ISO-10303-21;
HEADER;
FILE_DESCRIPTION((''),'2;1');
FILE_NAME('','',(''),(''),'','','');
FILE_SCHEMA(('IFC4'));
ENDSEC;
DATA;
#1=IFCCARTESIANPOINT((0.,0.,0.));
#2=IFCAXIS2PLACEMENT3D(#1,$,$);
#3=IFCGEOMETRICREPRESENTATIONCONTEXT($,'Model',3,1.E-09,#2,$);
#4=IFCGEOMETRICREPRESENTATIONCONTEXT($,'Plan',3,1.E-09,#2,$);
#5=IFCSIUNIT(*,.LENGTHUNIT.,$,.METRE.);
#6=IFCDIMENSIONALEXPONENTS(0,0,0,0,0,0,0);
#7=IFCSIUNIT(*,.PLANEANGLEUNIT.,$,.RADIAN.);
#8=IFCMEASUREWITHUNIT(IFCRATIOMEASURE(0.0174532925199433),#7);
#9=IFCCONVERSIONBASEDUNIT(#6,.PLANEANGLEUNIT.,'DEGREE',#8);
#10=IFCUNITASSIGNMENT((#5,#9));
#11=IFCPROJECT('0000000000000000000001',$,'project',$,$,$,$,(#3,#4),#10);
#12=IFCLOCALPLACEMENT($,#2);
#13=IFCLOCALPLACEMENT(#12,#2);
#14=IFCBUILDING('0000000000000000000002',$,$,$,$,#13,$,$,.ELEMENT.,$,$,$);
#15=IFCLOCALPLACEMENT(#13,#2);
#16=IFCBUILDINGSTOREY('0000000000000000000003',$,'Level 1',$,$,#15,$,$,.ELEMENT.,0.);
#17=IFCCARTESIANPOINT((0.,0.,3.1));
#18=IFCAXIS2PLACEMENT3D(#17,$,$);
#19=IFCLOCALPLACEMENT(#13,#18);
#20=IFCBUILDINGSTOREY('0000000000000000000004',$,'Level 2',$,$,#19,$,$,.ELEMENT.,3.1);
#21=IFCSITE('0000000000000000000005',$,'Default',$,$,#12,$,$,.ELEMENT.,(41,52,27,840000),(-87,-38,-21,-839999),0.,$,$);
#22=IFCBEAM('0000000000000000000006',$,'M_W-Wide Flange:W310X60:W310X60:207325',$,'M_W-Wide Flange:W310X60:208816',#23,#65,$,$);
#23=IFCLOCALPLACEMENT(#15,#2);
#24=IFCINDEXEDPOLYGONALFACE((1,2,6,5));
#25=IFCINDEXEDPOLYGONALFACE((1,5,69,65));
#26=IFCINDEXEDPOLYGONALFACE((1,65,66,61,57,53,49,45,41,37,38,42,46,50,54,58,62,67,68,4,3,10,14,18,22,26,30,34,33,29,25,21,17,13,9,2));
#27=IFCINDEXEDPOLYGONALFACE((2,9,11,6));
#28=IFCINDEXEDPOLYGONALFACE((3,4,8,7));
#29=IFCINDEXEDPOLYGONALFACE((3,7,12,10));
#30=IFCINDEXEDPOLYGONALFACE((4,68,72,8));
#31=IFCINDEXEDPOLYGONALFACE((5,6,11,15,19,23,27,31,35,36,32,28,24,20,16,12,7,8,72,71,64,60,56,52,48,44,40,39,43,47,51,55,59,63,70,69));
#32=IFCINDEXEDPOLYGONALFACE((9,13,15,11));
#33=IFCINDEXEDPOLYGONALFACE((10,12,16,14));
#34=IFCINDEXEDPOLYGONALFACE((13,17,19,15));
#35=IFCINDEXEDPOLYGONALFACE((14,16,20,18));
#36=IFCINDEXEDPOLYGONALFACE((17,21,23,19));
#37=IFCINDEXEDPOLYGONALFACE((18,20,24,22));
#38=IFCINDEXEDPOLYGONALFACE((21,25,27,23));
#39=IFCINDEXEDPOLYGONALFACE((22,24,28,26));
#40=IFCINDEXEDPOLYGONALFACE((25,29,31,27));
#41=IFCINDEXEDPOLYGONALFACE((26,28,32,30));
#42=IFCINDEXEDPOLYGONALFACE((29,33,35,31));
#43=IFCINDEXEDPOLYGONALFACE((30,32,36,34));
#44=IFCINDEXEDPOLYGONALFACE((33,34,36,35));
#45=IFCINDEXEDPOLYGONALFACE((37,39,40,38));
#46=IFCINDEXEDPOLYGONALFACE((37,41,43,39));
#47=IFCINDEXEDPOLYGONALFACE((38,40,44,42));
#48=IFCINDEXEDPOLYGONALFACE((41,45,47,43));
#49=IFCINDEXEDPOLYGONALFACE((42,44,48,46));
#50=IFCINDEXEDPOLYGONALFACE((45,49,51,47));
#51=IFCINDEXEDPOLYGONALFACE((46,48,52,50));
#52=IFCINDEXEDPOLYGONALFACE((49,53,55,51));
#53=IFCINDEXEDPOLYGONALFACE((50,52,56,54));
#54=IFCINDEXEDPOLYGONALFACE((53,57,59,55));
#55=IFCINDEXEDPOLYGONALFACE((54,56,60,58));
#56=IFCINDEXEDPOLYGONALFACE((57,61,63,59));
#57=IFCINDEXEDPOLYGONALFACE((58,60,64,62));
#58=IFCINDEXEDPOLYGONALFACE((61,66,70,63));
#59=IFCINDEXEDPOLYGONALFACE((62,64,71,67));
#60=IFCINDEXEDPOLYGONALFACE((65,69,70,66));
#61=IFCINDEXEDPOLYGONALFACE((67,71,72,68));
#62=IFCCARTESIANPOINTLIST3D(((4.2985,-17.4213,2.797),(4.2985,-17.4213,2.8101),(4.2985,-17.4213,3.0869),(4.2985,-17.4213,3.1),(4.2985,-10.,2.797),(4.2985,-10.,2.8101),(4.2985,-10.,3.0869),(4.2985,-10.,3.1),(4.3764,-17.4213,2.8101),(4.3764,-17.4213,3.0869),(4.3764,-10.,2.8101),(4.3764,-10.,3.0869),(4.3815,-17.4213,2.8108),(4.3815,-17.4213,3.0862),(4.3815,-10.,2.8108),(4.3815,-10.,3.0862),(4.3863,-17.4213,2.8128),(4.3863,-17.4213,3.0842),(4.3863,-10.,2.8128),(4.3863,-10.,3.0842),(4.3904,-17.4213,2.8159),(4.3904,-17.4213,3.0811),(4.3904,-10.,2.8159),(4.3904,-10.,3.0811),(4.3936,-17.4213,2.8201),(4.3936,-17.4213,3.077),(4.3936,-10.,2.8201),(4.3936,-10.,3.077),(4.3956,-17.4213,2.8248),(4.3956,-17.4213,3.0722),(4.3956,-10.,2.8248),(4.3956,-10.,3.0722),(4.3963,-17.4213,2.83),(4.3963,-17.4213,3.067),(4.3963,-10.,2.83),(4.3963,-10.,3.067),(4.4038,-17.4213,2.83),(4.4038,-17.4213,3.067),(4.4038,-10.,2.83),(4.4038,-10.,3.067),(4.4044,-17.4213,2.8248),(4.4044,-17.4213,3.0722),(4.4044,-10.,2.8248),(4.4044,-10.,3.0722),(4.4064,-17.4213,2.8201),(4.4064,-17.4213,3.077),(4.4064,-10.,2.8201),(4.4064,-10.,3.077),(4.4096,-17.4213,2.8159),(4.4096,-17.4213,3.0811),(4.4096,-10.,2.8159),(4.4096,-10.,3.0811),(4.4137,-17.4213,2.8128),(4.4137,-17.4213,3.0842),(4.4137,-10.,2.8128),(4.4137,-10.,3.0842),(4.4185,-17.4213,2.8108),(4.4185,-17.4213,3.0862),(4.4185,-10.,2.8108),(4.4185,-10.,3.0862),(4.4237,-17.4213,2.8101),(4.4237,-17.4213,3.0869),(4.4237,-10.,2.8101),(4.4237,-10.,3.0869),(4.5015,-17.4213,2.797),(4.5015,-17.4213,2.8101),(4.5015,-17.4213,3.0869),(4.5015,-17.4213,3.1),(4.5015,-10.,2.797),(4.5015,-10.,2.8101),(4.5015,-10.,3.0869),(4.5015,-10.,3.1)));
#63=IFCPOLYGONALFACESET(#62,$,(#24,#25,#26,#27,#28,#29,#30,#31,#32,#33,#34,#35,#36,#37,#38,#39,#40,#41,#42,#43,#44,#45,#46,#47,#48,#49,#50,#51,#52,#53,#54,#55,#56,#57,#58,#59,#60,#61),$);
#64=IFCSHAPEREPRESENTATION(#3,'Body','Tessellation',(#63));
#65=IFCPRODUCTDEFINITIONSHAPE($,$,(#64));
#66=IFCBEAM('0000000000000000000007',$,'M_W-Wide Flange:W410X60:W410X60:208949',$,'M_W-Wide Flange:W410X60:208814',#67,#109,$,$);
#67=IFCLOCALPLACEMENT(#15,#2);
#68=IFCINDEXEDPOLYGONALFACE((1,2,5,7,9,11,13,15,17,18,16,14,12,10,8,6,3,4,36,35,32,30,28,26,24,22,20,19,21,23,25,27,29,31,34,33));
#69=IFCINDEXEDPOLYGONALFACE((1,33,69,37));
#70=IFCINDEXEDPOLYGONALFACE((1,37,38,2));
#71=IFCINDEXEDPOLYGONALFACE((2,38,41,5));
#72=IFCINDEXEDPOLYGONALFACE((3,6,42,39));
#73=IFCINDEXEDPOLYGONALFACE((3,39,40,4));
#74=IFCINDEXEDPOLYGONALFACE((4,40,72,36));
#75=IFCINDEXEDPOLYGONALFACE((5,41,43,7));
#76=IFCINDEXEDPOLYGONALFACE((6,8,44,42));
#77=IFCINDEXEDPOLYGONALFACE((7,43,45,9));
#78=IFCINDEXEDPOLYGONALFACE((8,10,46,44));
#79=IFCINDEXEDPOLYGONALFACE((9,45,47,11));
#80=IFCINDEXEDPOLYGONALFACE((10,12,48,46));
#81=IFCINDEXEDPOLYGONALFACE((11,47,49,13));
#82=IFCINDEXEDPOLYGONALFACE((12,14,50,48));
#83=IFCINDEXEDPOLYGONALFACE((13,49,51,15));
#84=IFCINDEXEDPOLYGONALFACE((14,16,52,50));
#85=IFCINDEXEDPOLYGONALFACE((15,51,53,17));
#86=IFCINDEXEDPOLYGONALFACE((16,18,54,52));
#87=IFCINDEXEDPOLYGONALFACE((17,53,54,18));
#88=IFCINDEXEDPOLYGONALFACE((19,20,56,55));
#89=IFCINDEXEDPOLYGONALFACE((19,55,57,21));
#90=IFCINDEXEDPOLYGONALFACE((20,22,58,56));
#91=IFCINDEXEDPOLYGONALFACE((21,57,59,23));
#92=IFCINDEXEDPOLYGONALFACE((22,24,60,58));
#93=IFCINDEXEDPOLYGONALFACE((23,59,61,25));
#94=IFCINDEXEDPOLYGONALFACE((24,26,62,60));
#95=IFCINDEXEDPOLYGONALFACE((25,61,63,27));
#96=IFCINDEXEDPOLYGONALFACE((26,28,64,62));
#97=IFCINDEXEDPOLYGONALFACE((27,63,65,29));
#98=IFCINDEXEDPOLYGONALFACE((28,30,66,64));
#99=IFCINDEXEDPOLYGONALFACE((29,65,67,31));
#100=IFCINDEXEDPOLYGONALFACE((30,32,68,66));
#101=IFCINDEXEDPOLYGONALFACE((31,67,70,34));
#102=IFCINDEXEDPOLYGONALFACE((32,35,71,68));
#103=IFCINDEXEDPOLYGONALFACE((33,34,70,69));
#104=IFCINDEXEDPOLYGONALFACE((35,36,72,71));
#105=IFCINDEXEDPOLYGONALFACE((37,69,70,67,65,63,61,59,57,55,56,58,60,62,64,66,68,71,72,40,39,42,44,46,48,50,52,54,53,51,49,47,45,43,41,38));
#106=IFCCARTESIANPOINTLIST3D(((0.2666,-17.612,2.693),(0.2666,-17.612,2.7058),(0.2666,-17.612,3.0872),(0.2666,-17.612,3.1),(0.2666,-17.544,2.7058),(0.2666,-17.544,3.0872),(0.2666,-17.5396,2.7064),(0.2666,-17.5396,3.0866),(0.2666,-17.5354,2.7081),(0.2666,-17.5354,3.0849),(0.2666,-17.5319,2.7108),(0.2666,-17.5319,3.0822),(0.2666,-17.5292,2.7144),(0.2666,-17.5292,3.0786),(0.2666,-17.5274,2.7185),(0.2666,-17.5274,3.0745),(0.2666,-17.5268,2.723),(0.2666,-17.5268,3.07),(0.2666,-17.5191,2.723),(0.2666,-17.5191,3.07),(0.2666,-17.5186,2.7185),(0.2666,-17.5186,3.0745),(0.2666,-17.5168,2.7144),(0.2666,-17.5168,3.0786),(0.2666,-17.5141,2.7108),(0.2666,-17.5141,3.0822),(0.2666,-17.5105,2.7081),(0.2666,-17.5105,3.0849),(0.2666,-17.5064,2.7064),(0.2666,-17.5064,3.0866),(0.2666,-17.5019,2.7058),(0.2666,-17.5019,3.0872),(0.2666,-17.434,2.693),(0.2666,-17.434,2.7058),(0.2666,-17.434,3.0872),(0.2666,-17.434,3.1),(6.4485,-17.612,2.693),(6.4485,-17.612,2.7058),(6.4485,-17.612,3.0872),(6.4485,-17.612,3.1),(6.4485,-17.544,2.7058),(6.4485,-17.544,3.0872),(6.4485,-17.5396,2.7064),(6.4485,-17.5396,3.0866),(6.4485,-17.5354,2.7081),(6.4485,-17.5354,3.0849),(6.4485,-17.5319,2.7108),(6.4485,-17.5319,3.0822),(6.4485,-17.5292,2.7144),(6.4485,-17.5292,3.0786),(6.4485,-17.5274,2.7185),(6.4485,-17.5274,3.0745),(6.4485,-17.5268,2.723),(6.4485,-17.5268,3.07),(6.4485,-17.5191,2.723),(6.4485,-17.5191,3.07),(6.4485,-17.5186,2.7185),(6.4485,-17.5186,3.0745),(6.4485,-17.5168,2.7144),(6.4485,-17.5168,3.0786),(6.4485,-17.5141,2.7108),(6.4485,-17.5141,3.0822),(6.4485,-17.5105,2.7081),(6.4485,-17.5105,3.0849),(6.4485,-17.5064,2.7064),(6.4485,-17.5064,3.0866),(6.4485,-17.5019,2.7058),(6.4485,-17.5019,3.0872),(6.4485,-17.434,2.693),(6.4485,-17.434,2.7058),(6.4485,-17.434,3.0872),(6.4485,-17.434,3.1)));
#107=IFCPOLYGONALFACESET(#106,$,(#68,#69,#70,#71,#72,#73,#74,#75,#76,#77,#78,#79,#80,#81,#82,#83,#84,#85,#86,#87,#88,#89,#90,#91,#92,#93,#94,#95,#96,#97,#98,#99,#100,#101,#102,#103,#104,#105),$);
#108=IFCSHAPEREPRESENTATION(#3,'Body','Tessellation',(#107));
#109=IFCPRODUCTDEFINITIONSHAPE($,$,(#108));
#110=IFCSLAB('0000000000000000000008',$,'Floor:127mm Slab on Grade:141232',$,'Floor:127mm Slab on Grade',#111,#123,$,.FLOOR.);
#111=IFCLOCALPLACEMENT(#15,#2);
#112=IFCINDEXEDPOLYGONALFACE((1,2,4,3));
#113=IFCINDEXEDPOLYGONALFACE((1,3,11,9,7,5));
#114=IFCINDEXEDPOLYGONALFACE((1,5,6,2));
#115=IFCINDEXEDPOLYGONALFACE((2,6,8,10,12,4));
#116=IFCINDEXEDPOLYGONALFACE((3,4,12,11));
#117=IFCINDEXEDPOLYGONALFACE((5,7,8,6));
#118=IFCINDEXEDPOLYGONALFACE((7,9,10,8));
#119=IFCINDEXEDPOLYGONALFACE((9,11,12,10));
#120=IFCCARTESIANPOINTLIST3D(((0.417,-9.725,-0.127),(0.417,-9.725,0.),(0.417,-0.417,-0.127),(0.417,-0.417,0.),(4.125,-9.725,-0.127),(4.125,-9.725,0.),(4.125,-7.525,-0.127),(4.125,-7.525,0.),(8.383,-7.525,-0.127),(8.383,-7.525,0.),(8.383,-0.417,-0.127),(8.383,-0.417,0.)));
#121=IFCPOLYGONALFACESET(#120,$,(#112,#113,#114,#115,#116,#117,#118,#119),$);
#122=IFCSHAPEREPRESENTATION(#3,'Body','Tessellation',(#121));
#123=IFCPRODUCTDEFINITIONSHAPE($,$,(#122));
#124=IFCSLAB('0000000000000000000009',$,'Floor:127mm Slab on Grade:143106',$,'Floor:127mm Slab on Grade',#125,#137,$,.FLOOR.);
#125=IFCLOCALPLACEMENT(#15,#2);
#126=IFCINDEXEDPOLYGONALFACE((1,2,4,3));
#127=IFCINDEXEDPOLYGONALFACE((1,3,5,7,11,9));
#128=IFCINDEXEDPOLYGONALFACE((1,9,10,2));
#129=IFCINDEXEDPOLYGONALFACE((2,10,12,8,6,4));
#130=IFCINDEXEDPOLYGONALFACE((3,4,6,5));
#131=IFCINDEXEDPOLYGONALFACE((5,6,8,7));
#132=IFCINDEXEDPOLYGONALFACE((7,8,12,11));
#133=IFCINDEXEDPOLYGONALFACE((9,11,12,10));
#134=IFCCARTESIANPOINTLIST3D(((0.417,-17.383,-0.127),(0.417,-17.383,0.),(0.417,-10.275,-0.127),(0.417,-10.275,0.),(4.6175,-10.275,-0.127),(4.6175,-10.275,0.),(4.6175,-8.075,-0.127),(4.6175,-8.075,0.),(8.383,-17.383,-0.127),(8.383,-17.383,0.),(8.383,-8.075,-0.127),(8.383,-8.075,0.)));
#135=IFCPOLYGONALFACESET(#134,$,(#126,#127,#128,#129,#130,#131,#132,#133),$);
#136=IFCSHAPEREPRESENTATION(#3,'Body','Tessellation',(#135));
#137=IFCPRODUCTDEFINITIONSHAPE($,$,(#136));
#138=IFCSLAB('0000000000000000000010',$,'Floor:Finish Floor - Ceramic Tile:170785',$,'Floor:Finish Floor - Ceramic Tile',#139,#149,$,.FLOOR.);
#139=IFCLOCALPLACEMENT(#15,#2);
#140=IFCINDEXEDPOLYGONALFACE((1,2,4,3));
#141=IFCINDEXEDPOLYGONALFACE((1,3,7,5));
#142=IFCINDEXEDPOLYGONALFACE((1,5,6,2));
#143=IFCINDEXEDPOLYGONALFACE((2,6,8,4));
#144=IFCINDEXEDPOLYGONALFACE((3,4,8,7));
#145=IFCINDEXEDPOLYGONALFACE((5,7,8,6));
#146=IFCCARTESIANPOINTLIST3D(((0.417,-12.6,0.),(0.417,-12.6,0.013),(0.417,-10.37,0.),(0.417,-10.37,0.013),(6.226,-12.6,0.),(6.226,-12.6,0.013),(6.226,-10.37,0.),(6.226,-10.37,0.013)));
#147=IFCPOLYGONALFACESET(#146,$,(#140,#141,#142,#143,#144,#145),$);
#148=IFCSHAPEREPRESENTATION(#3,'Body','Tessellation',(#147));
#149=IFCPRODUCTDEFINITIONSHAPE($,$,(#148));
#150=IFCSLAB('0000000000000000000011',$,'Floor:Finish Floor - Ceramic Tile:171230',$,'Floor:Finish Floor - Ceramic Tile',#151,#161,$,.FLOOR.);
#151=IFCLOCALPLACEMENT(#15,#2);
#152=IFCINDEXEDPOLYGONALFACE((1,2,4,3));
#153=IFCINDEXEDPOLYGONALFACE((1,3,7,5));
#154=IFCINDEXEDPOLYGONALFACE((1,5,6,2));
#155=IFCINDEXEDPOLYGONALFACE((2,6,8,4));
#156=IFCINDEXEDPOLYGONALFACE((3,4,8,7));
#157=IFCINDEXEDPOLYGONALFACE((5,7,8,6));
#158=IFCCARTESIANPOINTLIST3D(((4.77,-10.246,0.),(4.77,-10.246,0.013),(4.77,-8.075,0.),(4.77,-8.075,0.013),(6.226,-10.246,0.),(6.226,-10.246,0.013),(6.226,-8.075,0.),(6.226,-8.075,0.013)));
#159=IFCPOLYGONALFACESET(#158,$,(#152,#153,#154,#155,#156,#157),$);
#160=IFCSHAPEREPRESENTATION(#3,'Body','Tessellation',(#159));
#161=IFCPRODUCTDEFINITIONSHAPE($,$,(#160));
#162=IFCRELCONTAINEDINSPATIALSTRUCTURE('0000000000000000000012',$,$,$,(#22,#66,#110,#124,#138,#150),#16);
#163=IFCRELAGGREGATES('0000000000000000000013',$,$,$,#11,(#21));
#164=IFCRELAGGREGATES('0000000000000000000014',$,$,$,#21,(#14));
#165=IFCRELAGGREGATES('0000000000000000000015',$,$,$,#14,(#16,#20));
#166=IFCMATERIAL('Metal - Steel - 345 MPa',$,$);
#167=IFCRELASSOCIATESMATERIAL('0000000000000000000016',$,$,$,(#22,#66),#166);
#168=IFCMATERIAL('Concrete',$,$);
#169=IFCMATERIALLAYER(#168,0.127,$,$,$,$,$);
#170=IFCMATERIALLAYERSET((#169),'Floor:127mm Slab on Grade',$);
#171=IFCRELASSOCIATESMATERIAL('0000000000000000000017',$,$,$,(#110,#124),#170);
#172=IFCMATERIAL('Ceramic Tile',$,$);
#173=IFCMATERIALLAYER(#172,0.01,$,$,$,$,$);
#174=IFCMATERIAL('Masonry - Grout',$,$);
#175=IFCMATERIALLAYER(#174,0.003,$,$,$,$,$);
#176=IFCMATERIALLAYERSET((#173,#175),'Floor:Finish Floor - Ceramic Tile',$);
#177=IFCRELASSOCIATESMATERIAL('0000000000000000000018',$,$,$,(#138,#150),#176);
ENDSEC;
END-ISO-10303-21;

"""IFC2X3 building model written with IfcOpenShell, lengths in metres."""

from ifc_helpers import new_model, entity, si_unit, converted_unit, frame, frame_2d, origin, place, context, project, spatial, polyline, circle_curve, parameter, trimmed, segment, composite_curve, rectangle, outline, extrude, material, layer, layer_set, layer_usage, element, save


model = new_model("IFC2X3")

# Units and contexts
model_context = context("Model", 3, precision=1e-09, world=origin())
plan_context = context("Plan", 3, precision=1e-09, world=origin())
ifc_project = project(units=[si_unit("LENGTHUNIT", "METRE"), converted_unit("PLANEANGLEUNIT", "DEGREE", entity("IfcRatioMeasure", 0.0174532925199433), si_unit("PLANEANGLEUNIT", "RADIAN"), dimensions=[0, 0, 0, 0, 0, 0, 0])], contexts=[model_context, plan_context])

# Site, building, storey
site_placement = place(None, origin())
site = spatial("IfcSite", under=ifc_project, at=site_placement, Name="Default", CompositionType="ELEMENT", RefLatitude=(41, 52, 27, 840000), RefLongitude=(-87, -38, -21, -839999), RefElevation=0.0)
building_placement = place(site_placement, origin())
building = spatial("IfcBuilding", under=site, at=building_placement, CompositionType="ELEMENT")
storey_1_placement = place(building_placement, origin())
storey_1 = spatial("IfcBuildingStorey", under=building, at=storey_1_placement, Name="Level 1", CompositionType="ELEMENT", Elevation=0.0)

# Beams
ifc_material_1 = material(Name="Metal - Steel - 345 MPa")
beam_1_placement = place(storey_1_placement, frame((4.4, -10.0, 3.1), z_axis=(0.0, 0.0, 1.0), x_axis=(-1.0, 0.0, 0.0)))
element("IfcBeam", 1, at=beam_1_placement, inside=storey_1, material=ifc_material_1, Name="M_W-Wide Flange:W310X60:W310X60:207325", ObjectType="M_W-Wide Flange:W310X60:208816", context=model_context, shape_type="SweptSolid", body=[
    extrude(outline(composite_curve([segment(polyline([(0.1384, -0.1015), (0.1515, -0.1015)]), True, "CONTINUOUS"), segment(polyline([(0.1515, -0.1015), (0.1515, 0.1015)]), True, "CONTINUOUS"), segment(polyline([(0.1515, 0.1015), (0.1384, 0.1015)]), True, "CONTINUOUS"), segment(polyline([(0.1384, 0.1015), (0.1384, 0.0236)]), True, "CONTINUOUS"), segment(trimmed(circle_curve(frame_2d((0.1185, 0.0236), x_axis=(0.0, 1.0)), 0.0199), [parameter(180.0)], [parameter(270.0)], True, "PARAMETER"), False, "CONTINUOUS"), segment(polyline([(0.1185, 0.0037), (-0.1185, 0.0037)]), True, "CONTINUOUS"), segment(trimmed(circle_curve(frame_2d((-0.1185, 0.0236), x_axis=(0.0, 1.0)), 0.0199), [parameter(90.0)], [parameter(180.0)], True, "PARAMETER"), False, "CONTINUOUS"), segment(polyline([(-0.1384, 0.0236), (-0.1384, 0.1015)]), True, "CONTINUOUS"), segment(polyline([(-0.1384, 0.1015), (-0.1515, 0.1015)]), True, "CONTINUOUS"), segment(polyline([(-0.1515, 0.1015), (-0.1515, -0.1015)]), True, "CONTINUOUS"), segment(polyline([(-0.1515, -0.1015), (-0.1384, -0.1015)]), True, "CONTINUOUS"), segment(polyline([(-0.1384, -0.1015), (-0.1384, -0.0237)]), True, "CONTINUOUS"), segment(trimmed(circle_curve(frame_2d((-0.1185, -0.0237), x_axis=(0.0, 1.0)), 0.0199), [parameter(360.0)], [parameter(90.0)], True, "PARAMETER"), False, "CONTINUOUS"), segment(polyline([(-0.1185, -0.0038), (0.1185, -0.0038)]), True, "CONTINUOUS"), segment(trimmed(circle_curve(frame_2d((0.1185, -0.0237), x_axis=(0.0, 1.0)), 0.0199), [parameter(270.0)], [parameter(0.0)], True, "PARAMETER"), False, "CONTINUOUS"), segment(polyline([(0.1384, -0.0237), (0.1384, -0.1015)]), True, "CONTINUOUS")], self_intersect=False)), frame((0.0, 7.4213, -0.1515), z_axis=(0.0, -1.0, 0.0), x_axis=(0.0, 0.0, -1.0)), (0.0, 0.0, 1.0), 7.4213),
])
beam_2_placement = place(storey_1_placement, frame((0.2085, -17.523, 3.1), z_axis=(0.0, 0.0, 1.0), x_axis=(0.0, -1.0, 0.0)))
element("IfcBeam", 2, at=beam_2_placement, inside=storey_1, material=ifc_material_1, Name="M_W-Wide Flange:W410X60:W410X60:208949", ObjectType="M_W-Wide Flange:W410X60:208814", context=model_context, shape_type="SweptSolid", body=[
    extrude(outline(composite_curve([segment(polyline([(-0.089, -0.1907), (-0.089, -0.2035)]), True, "CONTINUOUS"), segment(polyline([(-0.089, -0.2035), (0.089, -0.2035)]), True, "CONTINUOUS"), segment(polyline([(0.089, -0.2035), (0.089, -0.1907)]), True, "CONTINUOUS"), segment(polyline([(0.089, -0.1907), (0.021, -0.1907)]), True, "CONTINUOUS"), segment(trimmed(circle_curve(frame_2d((0.021, -0.1735), x_axis=(0.0, -1.0)), 0.0172), [parameter(270.0)], [parameter(360.0)], True, "PARAMETER"), False, "CONTINUOUS"), segment(polyline([(0.0038, -0.1735), (0.0038, 0.1735)]), True, "CONTINUOUS"), segment(trimmed(circle_curve(frame_2d((0.021, 0.1735), x_axis=(-1.0, 0.0)), 0.0172), [parameter(270.0)], [parameter(360.0)], True, "PARAMETER"), False, "CONTINUOUS"), segment(polyline([(0.021, 0.1907), (0.089, 0.1907)]), True, "CONTINUOUS"), segment(polyline([(0.089, 0.1907), (0.089, 0.2035)]), True, "CONTINUOUS"), segment(polyline([(0.089, 0.2035), (-0.089, 0.2035)]), True, "CONTINUOUS"), segment(polyline([(-0.089, 0.2035), (-0.089, 0.1907)]), True, "CONTINUOUS"), segment(polyline([(-0.089, 0.1907), (-0.0211, 0.1907)]), True, "CONTINUOUS"), segment(trimmed(circle_curve(frame_2d((-0.0211, 0.1735), x_axis=(0.0, 1.0)), 0.0172), [parameter(270.0)], [parameter(0.0)], True, "PARAMETER"), False, "CONTINUOUS"), segment(polyline([(-0.0039, 0.1735), (-0.0039, -0.1735)]), True, "CONTINUOUS"), segment(trimmed(circle_curve(frame_2d((-0.0211, -0.1735), x_axis=(1.0, 0.0)), 0.0172), [parameter(270.0)], [parameter(0.0)], True, "PARAMETER"), False, "CONTINUOUS"), segment(polyline([(-0.0211, -0.1907), (-0.089, -0.1907)]), True, "CONTINUOUS")], self_intersect=False)), frame((0.0, 0.0581, -0.2035), z_axis=(0.0, -1.0, 0.0), x_axis=(1.0, 0.0, 0.0)), (0.0, 0.0, -1.0), 6.1819),
])

# Slabs
ifc_material_2 = material(Name="Concrete")
ifc_layer_1 = layer(ifc_material_2, 0.127)
ifc_layer_set_1 = layer_set([ifc_layer_1], Name="Floor:127mm Slab on Grade")
ifc_layer_usage_1 = layer_usage(ifc_layer_set_1, "AXIS3", "POSITIVE", 0.0)
slab_1_placement = place(storey_1_placement, frame((0.417, -9.725, -0.127)))
element("IfcSlab", 3, at=slab_1_placement, inside=storey_1, material=ifc_layer_usage_1, Name="Floor:127mm Slab on Grade:141232", ObjectType="Floor:127mm Slab on Grade", PredefinedType="FLOOR", context=model_context, shape_type="SweptSolid", body=[
    extrude(outline(polyline([(-3.983, 4.654), (-3.983, -2.454), (0.275, -2.454), (0.275, -4.654), (3.983, -4.654), (3.983, 4.654), (-3.983, 4.654)])), frame((3.983, 4.654, 0.127), z_axis=(0.0, 0.0, -1.0), x_axis=(-1.0, 0.0, 0.0)), (0.0, 0.0, 1.0), 0.127),
])
ifc_layer_usage_2 = layer_usage(ifc_layer_set_1, "AXIS3", "POSITIVE", 0.0)
slab_2_placement = place(storey_1_placement, frame((0.417, -17.383, -0.127)))
element("IfcSlab", 4, at=slab_2_placement, inside=storey_1, material=ifc_layer_usage_2, Name="Floor:127mm Slab on Grade:143106", ObjectType="Floor:127mm Slab on Grade", PredefinedType="FLOOR", context=model_context, shape_type="SweptSolid", body=[
    extrude(outline(polyline([(-3.983, 4.654), (-3.983, -4.654), (3.983, -4.654), (3.983, 2.454), (-0.2175, 2.454), (-0.2175, 4.654), (-3.983, 4.654)])), frame((3.983, 4.654, 0.127), z_axis=(0.0, 0.0, -1.0), x_axis=(-1.0, 0.0, 0.0)), (0.0, 0.0, 1.0), 0.127),
])
ifc_material_3 = material(Name="Ceramic Tile")
ifc_layer_2 = layer(ifc_material_3, 0.01)
ifc_material_4 = material(Name="Masonry - Grout")
ifc_layer_3 = layer(ifc_material_4, 0.003)
ifc_layer_set_2 = layer_set([ifc_layer_2, ifc_layer_3], Name="Floor:Finish Floor - Ceramic Tile")
ifc_layer_usage_3 = layer_usage(ifc_layer_set_2, "AXIS3", "POSITIVE", 0.0)
slab_3_placement = place(storey_1_placement, frame((0.417, -12.6, 0.0)))
element("IfcSlab", 5, at=slab_3_placement, inside=storey_1, material=ifc_layer_usage_3, Name="Floor:Finish Floor - Ceramic Tile:170785", ObjectType="Floor:Finish Floor - Ceramic Tile", PredefinedType="FLOOR", context=model_context, shape_type="SweptSolid", body=[
    extrude(rectangle(XDim=5.809, YDim=2.23, at=frame_2d((0.0, 0.0), x_axis=(-1.0, 0.0))), frame((2.9045, 1.115, 0.013), z_axis=(0.0, 0.0, -1.0), x_axis=(-1.0, 0.0, 0.0)), (0.0, 0.0, 1.0), 0.013),
])
ifc_layer_usage_4 = layer_usage(ifc_layer_set_2, "AXIS3", "POSITIVE", 0.0)
slab_4_placement = place(storey_1_placement, frame((4.77, -10.246, 0.0)))
element("IfcSlab", 6, at=slab_4_placement, inside=storey_1, material=ifc_layer_usage_4, Name="Floor:Finish Floor - Ceramic Tile:171230", ObjectType="Floor:Finish Floor - Ceramic Tile", PredefinedType="FLOOR", context=model_context, shape_type="SweptSolid", body=[
    extrude(rectangle(XDim=1.456, YDim=2.171, at=frame_2d((0.0, 0.0), x_axis=(-1.0, 0.0))), frame((0.728, 1.0855, 0.013), z_axis=(0.0, 0.0, -1.0), x_axis=(-1.0, 0.0, 0.0)), (0.0, 0.0, 1.0), 0.013),
])

# Shared definitions
storey_2_placement = place(building_placement, frame((0.0, 0.0, 3.1)))
storey_2 = spatial("IfcBuildingStorey", under=building, at=storey_2_placement, Name="Level 2", CompositionType="ELEMENT", Elevation=3.1)

save(model, "model.ifc")
